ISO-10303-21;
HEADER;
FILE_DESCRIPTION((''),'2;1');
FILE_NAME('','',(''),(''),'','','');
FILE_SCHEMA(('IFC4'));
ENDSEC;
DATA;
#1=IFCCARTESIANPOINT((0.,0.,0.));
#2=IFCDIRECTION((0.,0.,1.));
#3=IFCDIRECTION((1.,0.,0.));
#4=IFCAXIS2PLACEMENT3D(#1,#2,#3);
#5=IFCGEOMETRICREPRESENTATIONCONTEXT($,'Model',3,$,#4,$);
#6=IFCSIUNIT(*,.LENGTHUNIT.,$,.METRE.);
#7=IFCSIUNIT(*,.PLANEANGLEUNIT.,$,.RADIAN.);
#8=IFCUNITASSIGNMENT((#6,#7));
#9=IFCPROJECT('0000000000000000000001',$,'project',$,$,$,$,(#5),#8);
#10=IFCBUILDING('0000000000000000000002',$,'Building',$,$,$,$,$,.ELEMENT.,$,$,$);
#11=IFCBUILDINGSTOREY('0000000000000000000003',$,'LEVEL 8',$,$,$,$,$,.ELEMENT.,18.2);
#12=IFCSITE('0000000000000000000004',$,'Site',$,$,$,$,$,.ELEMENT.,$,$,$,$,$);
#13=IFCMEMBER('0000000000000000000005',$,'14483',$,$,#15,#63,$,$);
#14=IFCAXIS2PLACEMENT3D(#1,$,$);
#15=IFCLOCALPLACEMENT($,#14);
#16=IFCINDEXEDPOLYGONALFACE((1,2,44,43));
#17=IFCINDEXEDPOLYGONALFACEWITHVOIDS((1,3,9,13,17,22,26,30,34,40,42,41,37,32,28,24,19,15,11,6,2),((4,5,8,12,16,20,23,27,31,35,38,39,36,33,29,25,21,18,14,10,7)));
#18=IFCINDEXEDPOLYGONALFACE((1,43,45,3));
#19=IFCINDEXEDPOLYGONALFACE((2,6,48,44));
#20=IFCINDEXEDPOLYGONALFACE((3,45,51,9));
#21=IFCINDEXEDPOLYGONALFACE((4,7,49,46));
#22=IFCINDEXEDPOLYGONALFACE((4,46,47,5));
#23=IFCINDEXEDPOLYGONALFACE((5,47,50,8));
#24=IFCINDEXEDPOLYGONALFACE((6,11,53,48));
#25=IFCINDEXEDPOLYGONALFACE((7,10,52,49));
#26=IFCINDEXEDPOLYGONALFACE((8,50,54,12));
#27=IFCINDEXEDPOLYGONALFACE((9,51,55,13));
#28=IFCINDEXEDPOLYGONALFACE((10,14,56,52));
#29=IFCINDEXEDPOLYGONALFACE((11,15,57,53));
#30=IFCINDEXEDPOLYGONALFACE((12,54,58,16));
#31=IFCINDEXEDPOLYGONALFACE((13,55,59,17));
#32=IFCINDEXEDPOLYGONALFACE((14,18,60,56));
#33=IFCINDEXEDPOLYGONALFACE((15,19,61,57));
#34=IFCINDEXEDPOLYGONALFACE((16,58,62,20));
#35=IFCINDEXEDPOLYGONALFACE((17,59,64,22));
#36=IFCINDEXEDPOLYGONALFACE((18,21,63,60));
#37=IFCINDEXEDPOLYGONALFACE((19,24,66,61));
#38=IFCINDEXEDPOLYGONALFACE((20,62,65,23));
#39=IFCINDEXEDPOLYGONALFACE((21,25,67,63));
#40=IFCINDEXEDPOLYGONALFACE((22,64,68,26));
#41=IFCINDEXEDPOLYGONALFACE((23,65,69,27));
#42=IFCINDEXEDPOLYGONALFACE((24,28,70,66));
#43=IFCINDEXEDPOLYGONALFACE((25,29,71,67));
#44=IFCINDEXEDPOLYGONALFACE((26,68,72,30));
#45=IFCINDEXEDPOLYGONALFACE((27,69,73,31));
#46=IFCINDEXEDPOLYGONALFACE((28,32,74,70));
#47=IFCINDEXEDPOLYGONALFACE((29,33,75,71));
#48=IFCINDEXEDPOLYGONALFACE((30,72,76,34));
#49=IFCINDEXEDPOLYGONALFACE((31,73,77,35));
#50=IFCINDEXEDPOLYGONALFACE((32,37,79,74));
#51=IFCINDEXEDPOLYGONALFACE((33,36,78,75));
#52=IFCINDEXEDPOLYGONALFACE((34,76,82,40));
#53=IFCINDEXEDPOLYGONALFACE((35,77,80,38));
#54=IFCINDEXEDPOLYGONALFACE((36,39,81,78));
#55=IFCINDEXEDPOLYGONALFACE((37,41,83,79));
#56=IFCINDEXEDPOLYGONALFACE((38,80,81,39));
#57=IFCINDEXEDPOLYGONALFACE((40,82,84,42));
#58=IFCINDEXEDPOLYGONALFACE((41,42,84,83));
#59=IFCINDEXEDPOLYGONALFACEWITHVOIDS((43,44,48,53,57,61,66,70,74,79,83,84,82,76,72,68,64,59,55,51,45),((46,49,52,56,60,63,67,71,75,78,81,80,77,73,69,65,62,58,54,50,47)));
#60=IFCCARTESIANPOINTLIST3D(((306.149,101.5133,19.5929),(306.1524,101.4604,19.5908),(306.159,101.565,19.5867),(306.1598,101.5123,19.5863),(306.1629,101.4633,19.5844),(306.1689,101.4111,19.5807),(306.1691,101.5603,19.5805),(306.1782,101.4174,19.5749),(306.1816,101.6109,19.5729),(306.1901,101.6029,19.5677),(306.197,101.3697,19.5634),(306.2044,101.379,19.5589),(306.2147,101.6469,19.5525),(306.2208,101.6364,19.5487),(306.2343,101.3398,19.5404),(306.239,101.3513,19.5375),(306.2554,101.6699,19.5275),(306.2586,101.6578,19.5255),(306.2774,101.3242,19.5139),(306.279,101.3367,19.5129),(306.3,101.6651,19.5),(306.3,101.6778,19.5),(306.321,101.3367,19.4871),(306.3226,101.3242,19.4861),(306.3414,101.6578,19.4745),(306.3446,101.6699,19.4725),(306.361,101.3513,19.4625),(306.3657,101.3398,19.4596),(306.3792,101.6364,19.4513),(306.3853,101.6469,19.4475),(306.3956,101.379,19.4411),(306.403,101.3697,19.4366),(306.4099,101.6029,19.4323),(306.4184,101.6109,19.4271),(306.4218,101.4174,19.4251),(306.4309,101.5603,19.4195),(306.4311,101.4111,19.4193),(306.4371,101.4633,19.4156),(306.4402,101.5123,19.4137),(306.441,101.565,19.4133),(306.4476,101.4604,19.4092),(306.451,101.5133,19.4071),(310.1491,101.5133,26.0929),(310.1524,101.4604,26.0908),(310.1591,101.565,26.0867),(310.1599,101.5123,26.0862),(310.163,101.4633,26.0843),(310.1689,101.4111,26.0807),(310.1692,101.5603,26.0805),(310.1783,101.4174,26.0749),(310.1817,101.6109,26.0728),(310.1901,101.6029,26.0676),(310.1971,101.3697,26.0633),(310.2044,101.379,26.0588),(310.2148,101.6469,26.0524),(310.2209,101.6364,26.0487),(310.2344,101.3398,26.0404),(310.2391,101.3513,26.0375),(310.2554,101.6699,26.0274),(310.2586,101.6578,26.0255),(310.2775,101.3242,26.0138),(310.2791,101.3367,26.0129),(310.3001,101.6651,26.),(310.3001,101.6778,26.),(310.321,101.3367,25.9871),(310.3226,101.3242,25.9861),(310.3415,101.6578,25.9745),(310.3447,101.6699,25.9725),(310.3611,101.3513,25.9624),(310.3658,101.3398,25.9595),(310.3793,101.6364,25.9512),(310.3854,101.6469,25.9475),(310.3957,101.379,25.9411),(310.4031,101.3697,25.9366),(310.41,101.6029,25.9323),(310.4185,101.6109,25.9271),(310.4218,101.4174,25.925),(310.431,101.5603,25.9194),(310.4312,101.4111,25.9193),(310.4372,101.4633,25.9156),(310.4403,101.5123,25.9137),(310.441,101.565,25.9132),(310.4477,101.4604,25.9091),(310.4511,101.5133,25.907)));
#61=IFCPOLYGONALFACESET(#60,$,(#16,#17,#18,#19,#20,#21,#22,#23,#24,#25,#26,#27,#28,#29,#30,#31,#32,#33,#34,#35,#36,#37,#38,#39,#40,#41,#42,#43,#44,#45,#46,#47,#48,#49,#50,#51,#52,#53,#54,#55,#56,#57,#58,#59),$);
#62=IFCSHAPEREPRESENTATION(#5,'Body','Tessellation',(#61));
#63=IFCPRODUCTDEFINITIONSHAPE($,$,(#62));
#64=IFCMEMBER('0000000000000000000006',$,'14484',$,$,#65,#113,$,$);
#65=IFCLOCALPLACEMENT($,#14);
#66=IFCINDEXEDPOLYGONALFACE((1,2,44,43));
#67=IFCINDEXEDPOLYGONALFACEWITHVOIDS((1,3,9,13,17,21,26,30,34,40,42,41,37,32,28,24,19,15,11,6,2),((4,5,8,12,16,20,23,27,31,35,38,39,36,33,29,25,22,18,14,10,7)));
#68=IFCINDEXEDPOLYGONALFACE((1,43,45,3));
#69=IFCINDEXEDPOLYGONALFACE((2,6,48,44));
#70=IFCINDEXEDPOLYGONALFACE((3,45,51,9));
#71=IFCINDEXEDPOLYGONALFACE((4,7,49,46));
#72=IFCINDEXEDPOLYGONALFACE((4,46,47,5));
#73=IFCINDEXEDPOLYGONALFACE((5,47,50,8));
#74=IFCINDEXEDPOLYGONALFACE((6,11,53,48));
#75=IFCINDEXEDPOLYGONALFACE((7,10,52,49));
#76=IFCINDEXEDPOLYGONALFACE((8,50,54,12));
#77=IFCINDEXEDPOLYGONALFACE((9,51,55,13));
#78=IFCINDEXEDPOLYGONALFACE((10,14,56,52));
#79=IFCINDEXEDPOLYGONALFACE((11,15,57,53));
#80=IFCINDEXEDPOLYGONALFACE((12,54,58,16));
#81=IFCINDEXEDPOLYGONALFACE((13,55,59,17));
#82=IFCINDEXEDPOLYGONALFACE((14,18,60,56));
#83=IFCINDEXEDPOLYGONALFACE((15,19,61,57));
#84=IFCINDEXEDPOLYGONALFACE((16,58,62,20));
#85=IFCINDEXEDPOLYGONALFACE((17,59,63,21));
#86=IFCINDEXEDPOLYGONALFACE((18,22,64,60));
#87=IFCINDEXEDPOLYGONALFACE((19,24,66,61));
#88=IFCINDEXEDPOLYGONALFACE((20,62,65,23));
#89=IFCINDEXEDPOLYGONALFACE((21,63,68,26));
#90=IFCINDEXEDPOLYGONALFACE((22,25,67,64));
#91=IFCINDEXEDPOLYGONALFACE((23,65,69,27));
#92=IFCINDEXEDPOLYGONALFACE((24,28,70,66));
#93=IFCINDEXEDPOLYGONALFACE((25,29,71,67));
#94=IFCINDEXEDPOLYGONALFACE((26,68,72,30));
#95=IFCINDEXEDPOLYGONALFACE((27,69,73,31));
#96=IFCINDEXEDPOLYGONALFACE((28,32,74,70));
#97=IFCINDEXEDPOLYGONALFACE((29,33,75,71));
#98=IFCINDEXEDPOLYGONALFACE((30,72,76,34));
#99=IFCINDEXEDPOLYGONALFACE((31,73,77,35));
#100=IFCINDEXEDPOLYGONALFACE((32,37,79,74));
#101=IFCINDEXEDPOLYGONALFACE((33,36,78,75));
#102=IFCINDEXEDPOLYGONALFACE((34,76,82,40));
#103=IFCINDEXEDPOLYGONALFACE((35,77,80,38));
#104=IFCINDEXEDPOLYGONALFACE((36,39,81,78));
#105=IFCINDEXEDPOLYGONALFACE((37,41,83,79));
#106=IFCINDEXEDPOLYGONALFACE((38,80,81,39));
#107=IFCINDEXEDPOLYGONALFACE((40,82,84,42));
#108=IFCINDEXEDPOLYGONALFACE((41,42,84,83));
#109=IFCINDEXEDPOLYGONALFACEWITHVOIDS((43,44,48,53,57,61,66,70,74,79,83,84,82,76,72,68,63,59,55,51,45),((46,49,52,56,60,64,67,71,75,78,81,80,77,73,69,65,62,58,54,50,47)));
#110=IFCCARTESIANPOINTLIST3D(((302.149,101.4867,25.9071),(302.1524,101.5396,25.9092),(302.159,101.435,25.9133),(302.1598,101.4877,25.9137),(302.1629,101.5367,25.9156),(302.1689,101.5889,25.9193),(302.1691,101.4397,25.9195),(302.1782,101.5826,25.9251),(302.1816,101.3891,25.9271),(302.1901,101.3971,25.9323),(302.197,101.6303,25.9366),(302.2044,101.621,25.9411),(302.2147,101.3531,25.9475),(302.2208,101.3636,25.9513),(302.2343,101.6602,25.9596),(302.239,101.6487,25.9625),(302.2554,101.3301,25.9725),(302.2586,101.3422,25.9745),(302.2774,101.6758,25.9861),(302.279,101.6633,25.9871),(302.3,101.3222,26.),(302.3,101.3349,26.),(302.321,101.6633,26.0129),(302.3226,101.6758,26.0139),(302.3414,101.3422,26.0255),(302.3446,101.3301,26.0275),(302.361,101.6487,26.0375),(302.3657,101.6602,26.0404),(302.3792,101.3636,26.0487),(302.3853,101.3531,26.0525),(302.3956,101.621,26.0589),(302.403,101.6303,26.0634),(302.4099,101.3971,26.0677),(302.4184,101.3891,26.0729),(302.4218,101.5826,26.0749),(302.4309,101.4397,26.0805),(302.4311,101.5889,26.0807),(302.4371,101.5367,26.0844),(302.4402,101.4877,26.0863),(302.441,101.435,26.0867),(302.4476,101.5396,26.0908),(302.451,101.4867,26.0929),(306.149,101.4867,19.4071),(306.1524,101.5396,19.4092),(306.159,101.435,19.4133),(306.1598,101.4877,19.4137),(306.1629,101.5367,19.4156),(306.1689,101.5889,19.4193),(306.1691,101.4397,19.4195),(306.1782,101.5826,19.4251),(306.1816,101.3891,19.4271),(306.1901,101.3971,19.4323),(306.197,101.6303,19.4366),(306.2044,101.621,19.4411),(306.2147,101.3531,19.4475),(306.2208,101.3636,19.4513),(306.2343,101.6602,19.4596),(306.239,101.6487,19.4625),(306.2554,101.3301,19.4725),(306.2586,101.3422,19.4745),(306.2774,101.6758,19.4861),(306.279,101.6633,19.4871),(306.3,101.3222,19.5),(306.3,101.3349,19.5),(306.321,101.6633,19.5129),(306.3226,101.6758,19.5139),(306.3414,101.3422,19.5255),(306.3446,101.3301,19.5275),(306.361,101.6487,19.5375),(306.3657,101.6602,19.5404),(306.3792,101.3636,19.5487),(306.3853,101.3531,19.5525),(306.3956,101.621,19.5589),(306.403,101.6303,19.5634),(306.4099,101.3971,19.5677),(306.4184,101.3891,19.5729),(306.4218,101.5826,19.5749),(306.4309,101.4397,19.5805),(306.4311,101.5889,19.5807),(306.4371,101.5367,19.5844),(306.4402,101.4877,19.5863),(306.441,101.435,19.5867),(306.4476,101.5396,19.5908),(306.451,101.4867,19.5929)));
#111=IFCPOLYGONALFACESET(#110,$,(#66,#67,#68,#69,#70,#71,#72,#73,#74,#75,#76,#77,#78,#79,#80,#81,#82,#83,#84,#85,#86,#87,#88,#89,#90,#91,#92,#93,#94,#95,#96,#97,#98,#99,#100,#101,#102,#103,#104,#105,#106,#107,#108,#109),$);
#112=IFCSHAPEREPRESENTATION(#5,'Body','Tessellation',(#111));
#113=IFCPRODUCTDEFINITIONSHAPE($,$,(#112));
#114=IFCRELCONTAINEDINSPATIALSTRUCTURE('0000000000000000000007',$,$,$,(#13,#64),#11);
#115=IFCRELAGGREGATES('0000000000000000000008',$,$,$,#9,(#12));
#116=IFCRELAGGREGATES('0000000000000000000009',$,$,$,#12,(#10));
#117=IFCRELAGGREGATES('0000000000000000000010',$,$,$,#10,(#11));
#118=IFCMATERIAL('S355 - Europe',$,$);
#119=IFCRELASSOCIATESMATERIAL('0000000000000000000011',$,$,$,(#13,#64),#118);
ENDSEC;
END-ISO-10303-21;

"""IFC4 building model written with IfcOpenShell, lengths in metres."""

from ifc_helpers import new_model, si_unit, frame, origin_with_axes, origin_2d_with_axis, place, context, project, spatial, hollow_circle, extrude, material, material_profile, profile_set, profile_usage, element, save


model = new_model("IFC4")

# Units and contexts
model_context = context("Model", 3, world=origin_with_axes())
ifc_project = project(units=[si_unit("LENGTHUNIT", "METRE"), si_unit("PLANEANGLEUNIT", "RADIAN")], contexts=[model_context])

# Site, building, storey
site = spatial("IfcSite", under=ifc_project, Name="Site", CompositionType="ELEMENT")
building = spatial("IfcBuilding", under=site, Name="Building", CompositionType="ELEMENT")
storey = spatial("IfcBuildingStorey", under=building, Name="LEVEL 8", CompositionType="ELEMENT", Elevation=18.2)

# Shared definitions
ifc_material = material(Name="S355 - Europe")

# Members
ifc_material_profile_1 = material_profile(ifc_material, hollow_circle(Radius=0.1778, WallThickness=0.0127, at=origin_2d_with_axis()))
ifc_profile_set_1 = profile_set([ifc_material_profile_1])
ifc_profile_usage_1 = profile_usage(ifc_profile_set_1, cardinal=10)
member_1_placement = place(None, frame((306.3, 101.5, 19.5), z_axis=(0.524107, 0.0, 0.851652), x_axis=(0.0, 1.0, 0.0)))
element("IfcMember", 1, at=member_1_placement, inside=storey, material=ifc_profile_usage_1, Name="14483", context=model_context, shape_type="SweptSolid", body=[
    extrude(hollow_circle(Radius=0.1778, WallThickness=0.0127, at=origin_2d_with_axis()), origin_with_axes(), (0.0, 0.0, 1.0), 7.6322),
])
ifc_material_profile_2 = material_profile(ifc_material, hollow_circle(Radius=0.1778, WallThickness=0.0127, at=origin_2d_with_axis()))
ifc_profile_set_2 = profile_set([ifc_material_profile_2])
ifc_profile_usage_2 = profile_usage(ifc_profile_set_2, cardinal=10)
member_2_placement = place(None, frame((306.3, 101.5, 19.5), z_axis=(-0.524097, 0.0, 0.851658), x_axis=(0.0, -1.0, 0.0)))
element("IfcMember", 2, at=member_2_placement, inside=storey, material=ifc_profile_usage_2, Name="14484", context=model_context, shape_type="SweptSolid", body=[
    extrude(hollow_circle(Radius=0.1778, WallThickness=0.0127, at=origin_2d_with_axis()), origin_with_axes(), (0.0, 0.0, 1.0), 7.6322),
])

save(model, "model.ifc")
